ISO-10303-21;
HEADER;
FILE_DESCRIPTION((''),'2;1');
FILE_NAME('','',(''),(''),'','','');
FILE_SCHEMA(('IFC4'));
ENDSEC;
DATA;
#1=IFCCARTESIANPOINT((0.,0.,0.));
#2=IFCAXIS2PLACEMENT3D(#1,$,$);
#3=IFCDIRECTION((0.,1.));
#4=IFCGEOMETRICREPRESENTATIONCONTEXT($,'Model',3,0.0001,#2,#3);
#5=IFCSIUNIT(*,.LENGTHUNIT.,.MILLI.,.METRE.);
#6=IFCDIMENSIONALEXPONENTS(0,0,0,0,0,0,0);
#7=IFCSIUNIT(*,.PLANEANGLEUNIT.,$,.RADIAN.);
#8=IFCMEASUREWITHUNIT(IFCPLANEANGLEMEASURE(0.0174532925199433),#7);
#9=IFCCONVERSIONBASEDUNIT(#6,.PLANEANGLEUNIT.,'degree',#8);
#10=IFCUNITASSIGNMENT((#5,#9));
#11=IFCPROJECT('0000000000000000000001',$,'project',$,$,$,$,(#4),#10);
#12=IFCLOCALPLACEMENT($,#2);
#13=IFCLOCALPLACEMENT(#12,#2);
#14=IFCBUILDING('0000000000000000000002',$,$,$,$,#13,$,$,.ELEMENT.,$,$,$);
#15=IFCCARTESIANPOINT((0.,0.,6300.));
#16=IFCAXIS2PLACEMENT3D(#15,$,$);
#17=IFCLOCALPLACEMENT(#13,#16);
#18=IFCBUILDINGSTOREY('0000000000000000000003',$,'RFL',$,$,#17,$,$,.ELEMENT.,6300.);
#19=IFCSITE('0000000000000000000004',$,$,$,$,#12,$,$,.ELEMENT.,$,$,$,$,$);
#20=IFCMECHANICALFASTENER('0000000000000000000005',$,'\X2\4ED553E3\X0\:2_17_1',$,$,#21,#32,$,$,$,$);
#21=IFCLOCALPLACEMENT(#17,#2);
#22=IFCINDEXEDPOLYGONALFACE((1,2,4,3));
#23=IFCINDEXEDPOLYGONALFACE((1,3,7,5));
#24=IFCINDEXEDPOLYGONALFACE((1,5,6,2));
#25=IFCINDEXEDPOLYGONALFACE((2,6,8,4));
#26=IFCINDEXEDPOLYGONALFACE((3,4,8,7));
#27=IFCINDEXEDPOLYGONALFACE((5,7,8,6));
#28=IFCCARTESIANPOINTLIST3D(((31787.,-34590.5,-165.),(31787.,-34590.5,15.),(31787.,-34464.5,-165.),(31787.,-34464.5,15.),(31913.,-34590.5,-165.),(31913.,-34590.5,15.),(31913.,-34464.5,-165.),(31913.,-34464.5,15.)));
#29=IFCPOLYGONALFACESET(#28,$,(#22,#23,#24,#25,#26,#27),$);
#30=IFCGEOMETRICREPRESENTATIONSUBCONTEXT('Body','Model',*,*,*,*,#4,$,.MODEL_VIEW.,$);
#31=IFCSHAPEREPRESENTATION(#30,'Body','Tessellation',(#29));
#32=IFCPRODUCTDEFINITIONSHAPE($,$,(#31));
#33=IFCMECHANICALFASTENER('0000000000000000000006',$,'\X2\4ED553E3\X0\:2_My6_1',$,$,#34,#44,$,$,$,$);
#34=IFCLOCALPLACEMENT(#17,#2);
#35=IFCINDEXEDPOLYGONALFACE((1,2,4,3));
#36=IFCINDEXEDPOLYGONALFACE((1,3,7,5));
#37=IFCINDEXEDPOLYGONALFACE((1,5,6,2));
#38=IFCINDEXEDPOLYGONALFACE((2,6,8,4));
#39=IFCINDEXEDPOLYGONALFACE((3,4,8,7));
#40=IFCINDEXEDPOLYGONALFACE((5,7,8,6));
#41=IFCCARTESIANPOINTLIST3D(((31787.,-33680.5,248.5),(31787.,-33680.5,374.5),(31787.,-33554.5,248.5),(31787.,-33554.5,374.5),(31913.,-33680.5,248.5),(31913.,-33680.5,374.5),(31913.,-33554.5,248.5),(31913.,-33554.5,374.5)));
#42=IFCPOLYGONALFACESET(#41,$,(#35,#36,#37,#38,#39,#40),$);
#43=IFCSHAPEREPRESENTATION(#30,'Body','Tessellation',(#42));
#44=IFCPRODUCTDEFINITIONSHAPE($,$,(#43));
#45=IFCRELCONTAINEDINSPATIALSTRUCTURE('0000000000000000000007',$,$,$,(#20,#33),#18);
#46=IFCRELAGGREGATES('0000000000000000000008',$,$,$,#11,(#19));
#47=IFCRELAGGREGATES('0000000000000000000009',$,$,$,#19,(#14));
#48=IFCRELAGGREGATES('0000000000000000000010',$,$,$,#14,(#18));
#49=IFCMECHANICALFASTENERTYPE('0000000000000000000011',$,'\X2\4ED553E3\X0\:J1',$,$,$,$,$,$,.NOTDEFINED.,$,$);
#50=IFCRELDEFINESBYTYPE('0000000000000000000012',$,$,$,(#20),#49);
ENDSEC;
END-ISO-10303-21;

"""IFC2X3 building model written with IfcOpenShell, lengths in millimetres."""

from ifc_helpers import new_model, entity, si_unit, converted_unit, direction, frame, origin, origin_with_axes, origin_2d, place, context, subcontext, project, spatial, rectangle, extrude, type_object, element, save


model = new_model("IFC2X3")

# Units and contexts
model_context = context("Model", 3, precision=0.0001, world=origin(), true_north=direction((0.0, 1.0)))
body_context = subcontext(model_context, "Body", "Model", "MODEL_VIEW")
ifc_project = project(units=[si_unit("LENGTHUNIT", "METRE", prefix="MILLI"), converted_unit("PLANEANGLEUNIT", "degree", entity("IfcPlaneAngleMeasure", 0.0174532925199433), si_unit("PLANEANGLEUNIT", "RADIAN"), dimensions=[0, 0, 0, 0, 0, 0, 0])], contexts=[model_context])

# Site, building, storey
site_placement = place(None, origin())
site = spatial("IfcSite", under=ifc_project, at=site_placement, CompositionType="ELEMENT")
building_placement = place(site_placement, origin())
building = spatial("IfcBuilding", under=site, at=building_placement, CompositionType="ELEMENT")
storey_placement = place(building_placement, frame((0.0, 0.0, 6300.0)))
storey = spatial("IfcBuildingStorey", under=building, at=storey_placement, Name="RFL", CompositionType="ELEMENT", Elevation=6300.0)

# Mechanical fasteners
mechanical_fastener_type_1 = type_object("IfcMechanicalFastenerType", Name="仕口:J1")
mechanical_fastener_1_placement = place(storey_placement, frame((31850.0, -34527.5, -165.0)))
element("IfcMechanicalFastener", 1, at=mechanical_fastener_1_placement, inside=storey, type_object=mechanical_fastener_type_1, Name="仕口:2_17_1", context=body_context, shape_type="SweptSolid", body=[
    extrude(rectangle(XDim=126.0, YDim=126.0, at=origin_2d()), origin_with_axes(), (0.0, 0.0, 1.0), 180.0),
])
mechanical_fastener_2_placement = place(storey_placement, frame((31850.0, -33617.5, 248.5)))
element("IfcMechanicalFastener", 2, at=mechanical_fastener_2_placement, inside=storey, Name="仕口:2_My6_1", context=body_context, shape_type="SweptSolid", body=[
    extrude(rectangle(XDim=126.0, YDim=126.0, at=origin_2d()), origin_with_axes(), (0.0, 0.0, 1.0), 126.0),
])

save(model, "model.ifc")
